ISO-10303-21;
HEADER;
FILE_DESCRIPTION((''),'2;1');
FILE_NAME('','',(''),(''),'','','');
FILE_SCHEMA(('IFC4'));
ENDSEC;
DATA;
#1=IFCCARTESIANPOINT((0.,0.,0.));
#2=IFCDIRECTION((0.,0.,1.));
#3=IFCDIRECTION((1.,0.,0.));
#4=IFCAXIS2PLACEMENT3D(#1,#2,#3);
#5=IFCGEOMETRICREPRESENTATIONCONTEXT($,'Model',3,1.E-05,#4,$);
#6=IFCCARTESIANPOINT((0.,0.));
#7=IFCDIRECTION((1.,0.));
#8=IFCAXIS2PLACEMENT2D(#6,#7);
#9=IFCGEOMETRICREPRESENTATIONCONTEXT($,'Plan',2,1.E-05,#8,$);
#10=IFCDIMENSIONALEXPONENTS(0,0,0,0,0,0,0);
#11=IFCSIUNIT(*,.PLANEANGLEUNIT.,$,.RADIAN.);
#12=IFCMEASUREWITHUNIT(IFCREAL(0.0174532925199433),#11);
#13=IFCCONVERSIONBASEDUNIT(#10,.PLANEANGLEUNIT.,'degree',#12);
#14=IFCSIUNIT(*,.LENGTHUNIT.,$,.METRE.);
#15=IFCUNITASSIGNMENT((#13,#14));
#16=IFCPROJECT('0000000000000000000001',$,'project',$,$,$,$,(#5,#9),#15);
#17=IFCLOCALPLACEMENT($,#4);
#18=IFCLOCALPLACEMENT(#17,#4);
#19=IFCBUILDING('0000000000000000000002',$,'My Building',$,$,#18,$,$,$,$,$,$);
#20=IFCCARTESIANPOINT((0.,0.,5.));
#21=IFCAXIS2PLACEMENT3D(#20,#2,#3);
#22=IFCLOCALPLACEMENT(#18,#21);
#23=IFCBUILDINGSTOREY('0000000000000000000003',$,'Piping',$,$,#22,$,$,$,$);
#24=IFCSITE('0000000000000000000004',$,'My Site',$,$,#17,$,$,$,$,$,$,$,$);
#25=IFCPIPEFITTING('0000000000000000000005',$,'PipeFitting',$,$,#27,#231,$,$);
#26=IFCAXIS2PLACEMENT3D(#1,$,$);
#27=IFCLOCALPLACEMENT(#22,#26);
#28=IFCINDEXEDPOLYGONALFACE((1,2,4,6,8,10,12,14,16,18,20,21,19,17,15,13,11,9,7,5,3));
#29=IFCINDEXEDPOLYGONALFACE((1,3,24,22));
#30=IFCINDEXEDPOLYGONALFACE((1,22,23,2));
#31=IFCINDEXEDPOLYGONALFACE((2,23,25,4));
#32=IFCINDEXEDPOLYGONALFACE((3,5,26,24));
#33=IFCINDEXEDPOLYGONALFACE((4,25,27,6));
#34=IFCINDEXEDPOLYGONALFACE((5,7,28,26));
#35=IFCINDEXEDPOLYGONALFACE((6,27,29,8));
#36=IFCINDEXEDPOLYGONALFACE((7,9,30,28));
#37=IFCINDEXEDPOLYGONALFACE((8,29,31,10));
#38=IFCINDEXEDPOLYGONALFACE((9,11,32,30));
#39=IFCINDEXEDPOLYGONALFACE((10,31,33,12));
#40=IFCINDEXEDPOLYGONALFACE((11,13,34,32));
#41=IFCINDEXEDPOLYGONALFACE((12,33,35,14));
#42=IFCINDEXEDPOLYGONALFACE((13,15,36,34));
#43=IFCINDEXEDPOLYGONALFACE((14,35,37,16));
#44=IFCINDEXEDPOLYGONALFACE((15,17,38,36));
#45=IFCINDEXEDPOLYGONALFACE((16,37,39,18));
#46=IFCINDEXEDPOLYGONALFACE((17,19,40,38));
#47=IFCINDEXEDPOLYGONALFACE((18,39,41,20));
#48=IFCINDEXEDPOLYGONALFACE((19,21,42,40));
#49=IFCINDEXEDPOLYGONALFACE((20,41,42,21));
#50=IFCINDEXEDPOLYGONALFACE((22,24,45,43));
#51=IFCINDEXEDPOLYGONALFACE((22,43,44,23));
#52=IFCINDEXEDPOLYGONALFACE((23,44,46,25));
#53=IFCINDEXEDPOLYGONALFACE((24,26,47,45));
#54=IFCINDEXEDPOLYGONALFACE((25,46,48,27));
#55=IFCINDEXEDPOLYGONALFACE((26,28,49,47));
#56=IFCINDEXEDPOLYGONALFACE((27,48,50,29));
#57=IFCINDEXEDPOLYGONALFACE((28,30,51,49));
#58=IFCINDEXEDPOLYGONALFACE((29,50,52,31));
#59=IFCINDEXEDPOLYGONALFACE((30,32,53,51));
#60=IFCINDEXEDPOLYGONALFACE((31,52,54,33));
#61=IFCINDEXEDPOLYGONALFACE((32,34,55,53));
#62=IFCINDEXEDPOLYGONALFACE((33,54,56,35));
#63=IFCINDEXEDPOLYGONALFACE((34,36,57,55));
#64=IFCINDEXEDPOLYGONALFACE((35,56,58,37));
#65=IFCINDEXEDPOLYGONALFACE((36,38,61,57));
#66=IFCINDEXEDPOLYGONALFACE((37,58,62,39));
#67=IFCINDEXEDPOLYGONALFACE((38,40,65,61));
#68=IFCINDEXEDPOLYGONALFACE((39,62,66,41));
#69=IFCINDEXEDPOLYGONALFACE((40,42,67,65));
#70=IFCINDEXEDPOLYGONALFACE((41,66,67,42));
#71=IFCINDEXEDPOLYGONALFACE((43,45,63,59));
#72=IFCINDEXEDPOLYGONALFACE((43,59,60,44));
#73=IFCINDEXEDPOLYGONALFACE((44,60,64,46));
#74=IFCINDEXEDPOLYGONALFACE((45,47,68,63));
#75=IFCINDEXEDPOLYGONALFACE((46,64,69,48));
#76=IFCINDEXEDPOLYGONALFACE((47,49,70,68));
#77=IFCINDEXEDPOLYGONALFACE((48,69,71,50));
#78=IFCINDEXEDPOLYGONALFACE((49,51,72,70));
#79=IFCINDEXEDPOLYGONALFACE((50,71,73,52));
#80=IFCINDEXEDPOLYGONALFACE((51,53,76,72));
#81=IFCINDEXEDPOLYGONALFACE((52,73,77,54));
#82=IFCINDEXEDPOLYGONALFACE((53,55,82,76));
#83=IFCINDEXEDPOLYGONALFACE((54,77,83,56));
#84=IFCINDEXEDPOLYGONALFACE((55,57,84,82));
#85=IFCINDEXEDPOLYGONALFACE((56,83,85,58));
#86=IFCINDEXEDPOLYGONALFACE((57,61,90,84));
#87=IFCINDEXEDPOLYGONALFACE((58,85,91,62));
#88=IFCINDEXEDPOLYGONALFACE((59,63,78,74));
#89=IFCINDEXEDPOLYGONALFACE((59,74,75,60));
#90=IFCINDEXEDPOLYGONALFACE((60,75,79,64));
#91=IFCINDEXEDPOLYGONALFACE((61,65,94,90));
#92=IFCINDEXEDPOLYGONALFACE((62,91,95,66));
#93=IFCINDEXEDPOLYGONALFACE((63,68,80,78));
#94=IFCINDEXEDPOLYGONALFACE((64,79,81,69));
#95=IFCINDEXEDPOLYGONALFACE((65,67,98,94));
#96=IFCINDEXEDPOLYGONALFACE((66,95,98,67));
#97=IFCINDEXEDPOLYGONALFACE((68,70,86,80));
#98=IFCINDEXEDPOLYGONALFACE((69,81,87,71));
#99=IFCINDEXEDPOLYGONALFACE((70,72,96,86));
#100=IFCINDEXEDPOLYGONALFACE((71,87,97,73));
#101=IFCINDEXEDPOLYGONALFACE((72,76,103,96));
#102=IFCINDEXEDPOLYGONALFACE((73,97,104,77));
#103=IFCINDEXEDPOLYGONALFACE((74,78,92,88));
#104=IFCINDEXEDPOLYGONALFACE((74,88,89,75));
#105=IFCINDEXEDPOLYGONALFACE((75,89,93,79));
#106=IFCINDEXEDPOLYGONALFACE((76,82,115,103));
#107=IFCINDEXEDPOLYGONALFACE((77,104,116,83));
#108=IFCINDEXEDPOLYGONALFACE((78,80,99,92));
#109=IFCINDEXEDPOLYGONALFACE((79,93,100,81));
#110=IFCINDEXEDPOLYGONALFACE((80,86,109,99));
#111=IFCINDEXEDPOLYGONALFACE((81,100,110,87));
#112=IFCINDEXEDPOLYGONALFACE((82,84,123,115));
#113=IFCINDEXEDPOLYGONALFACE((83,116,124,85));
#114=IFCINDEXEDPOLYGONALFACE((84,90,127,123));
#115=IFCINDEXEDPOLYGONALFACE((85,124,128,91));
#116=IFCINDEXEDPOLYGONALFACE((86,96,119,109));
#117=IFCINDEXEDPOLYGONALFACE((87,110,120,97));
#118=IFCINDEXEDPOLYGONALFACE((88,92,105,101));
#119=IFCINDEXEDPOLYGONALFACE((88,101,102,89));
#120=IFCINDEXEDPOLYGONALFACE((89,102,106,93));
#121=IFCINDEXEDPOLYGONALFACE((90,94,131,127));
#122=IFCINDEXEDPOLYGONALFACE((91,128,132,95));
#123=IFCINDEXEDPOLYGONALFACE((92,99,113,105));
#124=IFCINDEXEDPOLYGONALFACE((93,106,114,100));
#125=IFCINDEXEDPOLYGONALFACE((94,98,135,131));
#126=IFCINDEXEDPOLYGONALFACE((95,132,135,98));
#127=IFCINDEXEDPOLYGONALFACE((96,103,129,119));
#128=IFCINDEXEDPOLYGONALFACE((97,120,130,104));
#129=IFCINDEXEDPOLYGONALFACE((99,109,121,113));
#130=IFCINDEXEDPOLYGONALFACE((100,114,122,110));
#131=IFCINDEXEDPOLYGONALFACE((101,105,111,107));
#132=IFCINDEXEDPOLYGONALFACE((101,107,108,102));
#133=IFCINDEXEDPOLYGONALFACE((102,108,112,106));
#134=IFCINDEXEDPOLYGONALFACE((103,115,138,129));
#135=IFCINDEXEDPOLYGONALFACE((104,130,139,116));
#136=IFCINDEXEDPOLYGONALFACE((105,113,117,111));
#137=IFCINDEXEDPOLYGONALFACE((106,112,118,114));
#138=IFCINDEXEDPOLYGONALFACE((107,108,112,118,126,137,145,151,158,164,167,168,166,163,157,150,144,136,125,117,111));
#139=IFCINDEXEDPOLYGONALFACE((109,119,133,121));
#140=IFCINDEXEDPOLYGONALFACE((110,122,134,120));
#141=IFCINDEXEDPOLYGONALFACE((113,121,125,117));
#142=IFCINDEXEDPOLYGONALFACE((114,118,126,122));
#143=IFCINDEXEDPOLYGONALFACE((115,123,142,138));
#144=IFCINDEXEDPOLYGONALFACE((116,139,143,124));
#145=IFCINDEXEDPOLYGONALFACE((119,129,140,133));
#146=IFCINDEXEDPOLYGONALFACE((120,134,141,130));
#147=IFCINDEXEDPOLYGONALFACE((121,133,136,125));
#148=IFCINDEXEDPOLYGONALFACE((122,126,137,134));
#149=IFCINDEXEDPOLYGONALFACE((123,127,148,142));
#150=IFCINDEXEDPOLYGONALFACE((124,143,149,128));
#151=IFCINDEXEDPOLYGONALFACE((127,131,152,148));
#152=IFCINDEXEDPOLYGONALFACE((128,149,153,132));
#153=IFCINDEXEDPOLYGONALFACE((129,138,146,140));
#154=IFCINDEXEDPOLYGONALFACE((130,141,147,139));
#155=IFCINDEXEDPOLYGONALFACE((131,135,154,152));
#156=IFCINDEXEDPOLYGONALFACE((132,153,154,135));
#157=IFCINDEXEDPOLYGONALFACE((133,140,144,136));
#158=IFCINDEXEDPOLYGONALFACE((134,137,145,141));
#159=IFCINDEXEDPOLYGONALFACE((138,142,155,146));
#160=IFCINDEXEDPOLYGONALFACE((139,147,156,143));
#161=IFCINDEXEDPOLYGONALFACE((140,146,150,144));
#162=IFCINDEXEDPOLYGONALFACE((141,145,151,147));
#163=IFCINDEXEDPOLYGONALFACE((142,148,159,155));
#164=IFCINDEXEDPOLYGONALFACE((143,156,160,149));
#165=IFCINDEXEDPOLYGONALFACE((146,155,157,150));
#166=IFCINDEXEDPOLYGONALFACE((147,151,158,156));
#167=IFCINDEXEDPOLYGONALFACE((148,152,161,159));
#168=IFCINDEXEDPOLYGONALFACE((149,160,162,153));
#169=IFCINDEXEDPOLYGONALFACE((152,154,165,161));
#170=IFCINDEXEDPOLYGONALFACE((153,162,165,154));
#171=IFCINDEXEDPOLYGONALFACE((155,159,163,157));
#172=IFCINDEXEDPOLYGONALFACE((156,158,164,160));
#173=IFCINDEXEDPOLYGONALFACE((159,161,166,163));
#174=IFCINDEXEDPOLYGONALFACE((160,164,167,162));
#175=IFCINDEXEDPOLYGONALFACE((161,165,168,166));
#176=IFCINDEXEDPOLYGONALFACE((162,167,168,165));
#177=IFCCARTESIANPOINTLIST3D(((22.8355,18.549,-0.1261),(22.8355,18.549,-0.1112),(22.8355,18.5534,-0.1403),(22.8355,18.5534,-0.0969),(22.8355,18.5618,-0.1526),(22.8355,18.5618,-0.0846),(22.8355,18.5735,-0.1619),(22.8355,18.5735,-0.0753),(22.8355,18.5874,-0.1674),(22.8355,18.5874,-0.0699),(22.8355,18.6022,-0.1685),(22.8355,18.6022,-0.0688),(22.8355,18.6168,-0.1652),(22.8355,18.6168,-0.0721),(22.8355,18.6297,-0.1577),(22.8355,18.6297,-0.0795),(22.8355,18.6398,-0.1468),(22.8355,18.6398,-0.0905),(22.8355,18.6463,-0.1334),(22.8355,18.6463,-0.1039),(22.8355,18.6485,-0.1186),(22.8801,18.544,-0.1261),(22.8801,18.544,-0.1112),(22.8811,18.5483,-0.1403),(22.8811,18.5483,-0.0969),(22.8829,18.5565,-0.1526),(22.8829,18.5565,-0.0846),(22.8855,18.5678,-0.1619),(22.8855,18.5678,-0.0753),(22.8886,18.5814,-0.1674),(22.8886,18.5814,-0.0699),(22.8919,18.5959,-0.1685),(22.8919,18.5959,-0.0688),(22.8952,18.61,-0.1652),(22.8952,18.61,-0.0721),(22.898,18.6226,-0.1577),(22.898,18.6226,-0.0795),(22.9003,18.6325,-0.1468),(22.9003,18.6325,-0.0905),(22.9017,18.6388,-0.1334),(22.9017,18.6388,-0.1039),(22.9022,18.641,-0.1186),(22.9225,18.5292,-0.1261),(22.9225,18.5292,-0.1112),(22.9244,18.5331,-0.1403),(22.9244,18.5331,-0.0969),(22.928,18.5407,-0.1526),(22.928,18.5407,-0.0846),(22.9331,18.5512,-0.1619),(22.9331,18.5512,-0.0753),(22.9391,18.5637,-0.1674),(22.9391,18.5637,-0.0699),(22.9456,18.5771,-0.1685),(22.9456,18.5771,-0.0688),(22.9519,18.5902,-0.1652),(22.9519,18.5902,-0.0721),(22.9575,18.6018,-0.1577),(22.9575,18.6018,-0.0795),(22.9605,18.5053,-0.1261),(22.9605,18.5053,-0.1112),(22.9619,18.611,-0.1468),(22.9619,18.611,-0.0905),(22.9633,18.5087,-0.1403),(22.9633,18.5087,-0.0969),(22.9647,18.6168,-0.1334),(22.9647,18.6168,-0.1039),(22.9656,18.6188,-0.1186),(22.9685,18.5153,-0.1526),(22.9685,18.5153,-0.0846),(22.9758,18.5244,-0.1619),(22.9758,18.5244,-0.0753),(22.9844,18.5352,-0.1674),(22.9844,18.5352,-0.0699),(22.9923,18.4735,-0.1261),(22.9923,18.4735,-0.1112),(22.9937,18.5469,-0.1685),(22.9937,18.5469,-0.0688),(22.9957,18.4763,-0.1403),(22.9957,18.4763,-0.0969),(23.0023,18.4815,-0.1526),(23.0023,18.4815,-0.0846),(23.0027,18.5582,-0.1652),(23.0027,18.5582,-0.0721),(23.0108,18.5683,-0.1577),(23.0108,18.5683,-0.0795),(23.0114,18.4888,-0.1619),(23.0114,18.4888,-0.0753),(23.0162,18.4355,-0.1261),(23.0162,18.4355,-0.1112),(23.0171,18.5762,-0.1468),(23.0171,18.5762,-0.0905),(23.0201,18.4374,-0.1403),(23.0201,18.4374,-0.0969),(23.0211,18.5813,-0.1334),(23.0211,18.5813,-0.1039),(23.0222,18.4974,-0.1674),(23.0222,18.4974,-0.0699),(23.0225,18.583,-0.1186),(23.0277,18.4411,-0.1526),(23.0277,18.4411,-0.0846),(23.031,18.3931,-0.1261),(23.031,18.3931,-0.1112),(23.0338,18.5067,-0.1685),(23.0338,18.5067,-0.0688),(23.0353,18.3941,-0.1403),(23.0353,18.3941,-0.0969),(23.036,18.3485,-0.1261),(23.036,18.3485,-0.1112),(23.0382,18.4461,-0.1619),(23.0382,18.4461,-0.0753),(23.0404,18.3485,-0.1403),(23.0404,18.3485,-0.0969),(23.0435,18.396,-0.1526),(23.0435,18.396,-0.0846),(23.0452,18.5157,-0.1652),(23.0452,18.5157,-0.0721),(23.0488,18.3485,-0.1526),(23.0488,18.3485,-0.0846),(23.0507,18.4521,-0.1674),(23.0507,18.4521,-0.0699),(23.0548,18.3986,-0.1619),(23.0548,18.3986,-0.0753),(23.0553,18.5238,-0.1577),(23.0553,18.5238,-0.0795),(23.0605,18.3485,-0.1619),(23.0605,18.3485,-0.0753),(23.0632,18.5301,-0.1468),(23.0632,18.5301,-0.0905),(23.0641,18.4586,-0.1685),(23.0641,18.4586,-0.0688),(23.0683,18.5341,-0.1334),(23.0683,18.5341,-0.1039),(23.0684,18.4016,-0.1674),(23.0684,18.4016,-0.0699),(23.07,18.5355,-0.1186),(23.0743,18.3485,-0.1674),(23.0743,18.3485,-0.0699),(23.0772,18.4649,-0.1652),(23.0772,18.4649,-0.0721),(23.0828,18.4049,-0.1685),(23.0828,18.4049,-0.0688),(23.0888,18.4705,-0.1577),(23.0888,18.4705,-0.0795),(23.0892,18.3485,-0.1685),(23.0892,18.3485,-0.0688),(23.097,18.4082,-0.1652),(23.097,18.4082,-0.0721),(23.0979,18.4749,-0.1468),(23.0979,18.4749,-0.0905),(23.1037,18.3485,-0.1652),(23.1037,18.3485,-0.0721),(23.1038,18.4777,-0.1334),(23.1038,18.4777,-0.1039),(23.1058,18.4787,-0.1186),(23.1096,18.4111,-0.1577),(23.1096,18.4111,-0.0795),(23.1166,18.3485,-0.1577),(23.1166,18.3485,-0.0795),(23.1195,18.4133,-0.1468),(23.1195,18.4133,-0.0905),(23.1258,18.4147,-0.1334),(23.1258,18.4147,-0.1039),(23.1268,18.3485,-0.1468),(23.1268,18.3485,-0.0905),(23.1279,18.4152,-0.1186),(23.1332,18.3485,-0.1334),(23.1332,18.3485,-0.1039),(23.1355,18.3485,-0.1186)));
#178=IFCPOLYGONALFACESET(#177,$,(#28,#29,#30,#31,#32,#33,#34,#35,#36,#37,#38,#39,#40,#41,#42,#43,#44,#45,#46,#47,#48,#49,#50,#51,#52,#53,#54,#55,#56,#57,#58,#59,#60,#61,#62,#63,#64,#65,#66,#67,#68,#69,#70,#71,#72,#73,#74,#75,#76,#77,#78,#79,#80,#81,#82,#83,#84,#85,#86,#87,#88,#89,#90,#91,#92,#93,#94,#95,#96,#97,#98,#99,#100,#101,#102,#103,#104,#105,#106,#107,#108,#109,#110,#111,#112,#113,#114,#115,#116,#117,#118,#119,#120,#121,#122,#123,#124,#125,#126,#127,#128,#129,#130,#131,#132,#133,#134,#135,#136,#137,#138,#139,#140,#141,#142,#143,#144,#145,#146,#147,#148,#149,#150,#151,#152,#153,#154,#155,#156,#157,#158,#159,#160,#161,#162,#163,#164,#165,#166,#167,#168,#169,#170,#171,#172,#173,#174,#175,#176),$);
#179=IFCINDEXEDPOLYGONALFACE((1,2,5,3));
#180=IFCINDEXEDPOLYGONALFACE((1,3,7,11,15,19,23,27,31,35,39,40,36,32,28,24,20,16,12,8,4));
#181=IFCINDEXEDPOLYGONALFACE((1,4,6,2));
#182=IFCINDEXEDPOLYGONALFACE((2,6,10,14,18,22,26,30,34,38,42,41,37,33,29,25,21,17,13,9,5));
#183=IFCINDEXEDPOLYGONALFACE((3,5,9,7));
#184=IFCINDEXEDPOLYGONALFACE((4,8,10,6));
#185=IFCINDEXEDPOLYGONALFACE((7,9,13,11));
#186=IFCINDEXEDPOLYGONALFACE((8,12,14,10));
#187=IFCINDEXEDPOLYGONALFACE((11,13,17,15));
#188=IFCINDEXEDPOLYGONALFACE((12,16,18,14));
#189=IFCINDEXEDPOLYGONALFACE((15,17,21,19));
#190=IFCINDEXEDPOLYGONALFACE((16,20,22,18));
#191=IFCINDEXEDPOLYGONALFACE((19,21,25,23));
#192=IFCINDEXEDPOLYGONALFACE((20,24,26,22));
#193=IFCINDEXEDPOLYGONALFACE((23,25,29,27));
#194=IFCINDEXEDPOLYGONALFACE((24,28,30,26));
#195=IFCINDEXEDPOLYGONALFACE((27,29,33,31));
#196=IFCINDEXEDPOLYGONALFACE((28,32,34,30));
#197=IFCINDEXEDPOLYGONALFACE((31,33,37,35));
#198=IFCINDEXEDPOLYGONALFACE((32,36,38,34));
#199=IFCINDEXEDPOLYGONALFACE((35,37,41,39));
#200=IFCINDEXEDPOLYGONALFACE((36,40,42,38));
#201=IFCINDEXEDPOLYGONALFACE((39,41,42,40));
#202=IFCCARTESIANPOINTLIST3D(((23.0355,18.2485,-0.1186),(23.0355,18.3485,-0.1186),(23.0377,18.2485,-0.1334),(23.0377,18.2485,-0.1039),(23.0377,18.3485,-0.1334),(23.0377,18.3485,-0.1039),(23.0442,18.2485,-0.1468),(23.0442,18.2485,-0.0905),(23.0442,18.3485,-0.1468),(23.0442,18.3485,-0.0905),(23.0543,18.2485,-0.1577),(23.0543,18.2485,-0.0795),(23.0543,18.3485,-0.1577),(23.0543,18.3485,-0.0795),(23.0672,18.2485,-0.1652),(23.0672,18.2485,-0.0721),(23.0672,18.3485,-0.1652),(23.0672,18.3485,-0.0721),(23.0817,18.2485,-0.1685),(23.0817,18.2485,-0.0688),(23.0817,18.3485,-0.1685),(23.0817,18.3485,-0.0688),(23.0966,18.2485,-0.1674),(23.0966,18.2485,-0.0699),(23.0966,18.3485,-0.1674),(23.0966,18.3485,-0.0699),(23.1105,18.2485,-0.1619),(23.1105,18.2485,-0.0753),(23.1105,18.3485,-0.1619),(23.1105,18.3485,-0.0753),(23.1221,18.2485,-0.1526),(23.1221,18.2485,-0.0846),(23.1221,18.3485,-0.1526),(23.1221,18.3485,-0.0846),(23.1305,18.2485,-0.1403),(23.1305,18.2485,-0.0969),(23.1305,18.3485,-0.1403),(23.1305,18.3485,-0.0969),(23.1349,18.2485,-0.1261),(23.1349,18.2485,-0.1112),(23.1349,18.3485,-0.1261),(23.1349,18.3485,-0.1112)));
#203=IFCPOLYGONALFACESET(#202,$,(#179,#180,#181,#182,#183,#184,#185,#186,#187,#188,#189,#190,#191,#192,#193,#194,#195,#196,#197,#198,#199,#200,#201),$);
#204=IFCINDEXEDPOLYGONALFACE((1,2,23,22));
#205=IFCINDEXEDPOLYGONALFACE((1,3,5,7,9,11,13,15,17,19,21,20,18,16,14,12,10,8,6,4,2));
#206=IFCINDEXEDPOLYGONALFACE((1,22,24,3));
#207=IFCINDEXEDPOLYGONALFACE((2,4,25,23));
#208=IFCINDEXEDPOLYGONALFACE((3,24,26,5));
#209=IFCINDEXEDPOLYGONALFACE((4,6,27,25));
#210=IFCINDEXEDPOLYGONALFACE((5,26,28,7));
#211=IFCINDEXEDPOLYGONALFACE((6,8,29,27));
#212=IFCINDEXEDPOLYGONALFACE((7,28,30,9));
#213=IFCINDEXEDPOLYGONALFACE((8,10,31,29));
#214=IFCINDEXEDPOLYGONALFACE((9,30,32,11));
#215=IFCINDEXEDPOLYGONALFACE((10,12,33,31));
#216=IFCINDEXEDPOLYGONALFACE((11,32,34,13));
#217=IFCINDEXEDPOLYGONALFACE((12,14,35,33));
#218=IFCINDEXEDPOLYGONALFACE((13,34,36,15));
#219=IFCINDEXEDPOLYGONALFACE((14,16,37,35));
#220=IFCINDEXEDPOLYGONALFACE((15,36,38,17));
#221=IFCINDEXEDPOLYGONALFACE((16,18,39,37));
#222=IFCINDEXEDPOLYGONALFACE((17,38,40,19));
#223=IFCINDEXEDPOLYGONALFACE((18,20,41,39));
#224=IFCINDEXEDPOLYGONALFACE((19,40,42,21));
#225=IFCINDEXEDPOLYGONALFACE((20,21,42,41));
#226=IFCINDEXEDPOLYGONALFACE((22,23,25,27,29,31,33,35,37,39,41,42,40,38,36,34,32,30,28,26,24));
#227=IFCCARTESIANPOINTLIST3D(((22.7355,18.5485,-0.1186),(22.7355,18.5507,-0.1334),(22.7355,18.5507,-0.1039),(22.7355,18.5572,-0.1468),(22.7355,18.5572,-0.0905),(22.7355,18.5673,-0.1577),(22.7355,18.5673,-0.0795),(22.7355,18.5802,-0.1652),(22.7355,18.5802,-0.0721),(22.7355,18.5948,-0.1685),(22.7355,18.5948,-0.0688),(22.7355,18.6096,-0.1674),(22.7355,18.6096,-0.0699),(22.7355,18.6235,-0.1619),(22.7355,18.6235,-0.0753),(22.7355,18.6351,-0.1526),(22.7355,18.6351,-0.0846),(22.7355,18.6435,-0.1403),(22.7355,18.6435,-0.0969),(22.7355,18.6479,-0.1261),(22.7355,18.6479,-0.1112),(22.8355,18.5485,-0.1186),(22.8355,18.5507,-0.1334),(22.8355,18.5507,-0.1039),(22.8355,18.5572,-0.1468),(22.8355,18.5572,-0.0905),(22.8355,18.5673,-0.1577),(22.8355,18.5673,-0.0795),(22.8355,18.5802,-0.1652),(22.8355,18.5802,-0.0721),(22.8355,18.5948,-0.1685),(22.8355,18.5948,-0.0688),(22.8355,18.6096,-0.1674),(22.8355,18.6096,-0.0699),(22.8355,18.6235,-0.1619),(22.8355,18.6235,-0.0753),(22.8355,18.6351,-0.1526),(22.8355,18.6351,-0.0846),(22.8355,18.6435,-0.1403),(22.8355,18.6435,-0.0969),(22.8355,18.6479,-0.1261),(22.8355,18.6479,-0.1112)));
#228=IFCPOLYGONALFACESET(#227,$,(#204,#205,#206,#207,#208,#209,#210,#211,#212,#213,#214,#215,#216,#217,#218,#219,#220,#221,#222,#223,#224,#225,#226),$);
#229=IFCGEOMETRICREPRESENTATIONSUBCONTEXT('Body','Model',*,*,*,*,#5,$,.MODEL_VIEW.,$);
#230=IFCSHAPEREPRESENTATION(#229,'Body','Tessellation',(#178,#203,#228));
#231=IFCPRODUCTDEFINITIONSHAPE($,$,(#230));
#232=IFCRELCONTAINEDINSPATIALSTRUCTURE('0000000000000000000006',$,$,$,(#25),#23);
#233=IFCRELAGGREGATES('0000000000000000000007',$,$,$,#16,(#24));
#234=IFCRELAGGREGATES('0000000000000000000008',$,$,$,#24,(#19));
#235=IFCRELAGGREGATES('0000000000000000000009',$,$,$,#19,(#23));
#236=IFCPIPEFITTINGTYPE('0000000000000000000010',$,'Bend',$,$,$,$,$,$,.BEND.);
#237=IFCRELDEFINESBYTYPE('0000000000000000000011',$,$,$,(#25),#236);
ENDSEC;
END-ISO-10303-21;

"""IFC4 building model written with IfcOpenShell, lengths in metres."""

from ifc_helpers import new_model, entity, si_unit, converted_unit, frame, origin_with_axes, origin_2d_with_axis, place, context, subcontext, project, spatial, circle, extrude, source, transform, mapped, type_object, type_shapes, element, save


model = new_model("IFC4")

# Units and contexts
model_context = context("Model", 3, precision=1e-05, world=origin_with_axes())
plan_context = context("Plan", 2, precision=1e-05, world=origin_2d_with_axis())
body_context = subcontext(model_context, "Body", "Model", "MODEL_VIEW")
ifc_project = project(units=[converted_unit("PLANEANGLEUNIT", "degree", entity("IfcReal", 0.0174532925199433), si_unit("PLANEANGLEUNIT", "RADIAN"), dimensions=[0, 0, 0, 0, 0, 0, 0]), si_unit("LENGTHUNIT", "METRE")], contexts=[model_context, plan_context])

# Site, building, storey
site_placement = place(None, origin_with_axes())
site = spatial("IfcSite", under=ifc_project, at=site_placement, Name="My Site")
building_placement = place(site_placement, origin_with_axes())
building = spatial("IfcBuilding", under=site, at=building_placement, Name="My Building")
storey_placement = place(building_placement, frame((0.0, 0.0, 5.0), z_axis=(0.0, 0.0, 1.0), x_axis=(1.0, 0.0, 0.0)))
storey = spatial("IfcBuildingStorey", under=building, at=storey_placement, Name="Piping")

# Pipe fitting
pipe_fitting_type_1 = type_object("IfcPipeFittingType", Name="Bend", PredefinedType="BEND")
shared_shape = source(origin_with_axes(), body_context, "Body", "SolidModel", [
    entity("IfcSweptDiskSolid", entity("IfcIndexedPolyCurve", entity("IfcCartesianPointList3D", [[0.0, 0.0, -0.1], [0.0732, 0.0, -0.2768], [0.25, 0.0, -0.35]]), [entity("IfcArcIndex", [1, 2, 3])]), 0.05),
    extrude(circle(Radius=0.05), origin_with_axes(), (0.0, 0.0, -1.0), 0.1),
    extrude(circle(Radius=0.05), frame((0.25, 0.0, -0.35), z_axis=(1.0, 0.0, 0.0), x_axis=(0.0, 0.0, 1.0)), (0.0, 0.0, 1.0), 0.1),
])
type_shapes(pipe_fitting_type_1, [shared_shape])
for number, where, z_axis, x_axis, name in (
    (1, (23.0855, 18.2485, -0.1186), (0.0, -1.0, -0.000001), (-1.0, 0.0, 0.0), "PipeFitting"),
):
    element("IfcPipeFitting", number, at=place(storey_placement, frame(where, z_axis=z_axis, x_axis=x_axis)), inside=storey, type_object=pipe_fitting_type_1, Name=name, context=body_context, shape_type="MappedRepresentation", body=[
        mapped(shared_shape, transform((0.0, 0.0, 0.0), x_axis=(1.0, 0.0, 0.0), y_axis=(0.0, 1.0, 0.0), z_axis=(0.0, 0.0, 1.0), scale=1.0)),
    ])

save(model, "model.ifc")
